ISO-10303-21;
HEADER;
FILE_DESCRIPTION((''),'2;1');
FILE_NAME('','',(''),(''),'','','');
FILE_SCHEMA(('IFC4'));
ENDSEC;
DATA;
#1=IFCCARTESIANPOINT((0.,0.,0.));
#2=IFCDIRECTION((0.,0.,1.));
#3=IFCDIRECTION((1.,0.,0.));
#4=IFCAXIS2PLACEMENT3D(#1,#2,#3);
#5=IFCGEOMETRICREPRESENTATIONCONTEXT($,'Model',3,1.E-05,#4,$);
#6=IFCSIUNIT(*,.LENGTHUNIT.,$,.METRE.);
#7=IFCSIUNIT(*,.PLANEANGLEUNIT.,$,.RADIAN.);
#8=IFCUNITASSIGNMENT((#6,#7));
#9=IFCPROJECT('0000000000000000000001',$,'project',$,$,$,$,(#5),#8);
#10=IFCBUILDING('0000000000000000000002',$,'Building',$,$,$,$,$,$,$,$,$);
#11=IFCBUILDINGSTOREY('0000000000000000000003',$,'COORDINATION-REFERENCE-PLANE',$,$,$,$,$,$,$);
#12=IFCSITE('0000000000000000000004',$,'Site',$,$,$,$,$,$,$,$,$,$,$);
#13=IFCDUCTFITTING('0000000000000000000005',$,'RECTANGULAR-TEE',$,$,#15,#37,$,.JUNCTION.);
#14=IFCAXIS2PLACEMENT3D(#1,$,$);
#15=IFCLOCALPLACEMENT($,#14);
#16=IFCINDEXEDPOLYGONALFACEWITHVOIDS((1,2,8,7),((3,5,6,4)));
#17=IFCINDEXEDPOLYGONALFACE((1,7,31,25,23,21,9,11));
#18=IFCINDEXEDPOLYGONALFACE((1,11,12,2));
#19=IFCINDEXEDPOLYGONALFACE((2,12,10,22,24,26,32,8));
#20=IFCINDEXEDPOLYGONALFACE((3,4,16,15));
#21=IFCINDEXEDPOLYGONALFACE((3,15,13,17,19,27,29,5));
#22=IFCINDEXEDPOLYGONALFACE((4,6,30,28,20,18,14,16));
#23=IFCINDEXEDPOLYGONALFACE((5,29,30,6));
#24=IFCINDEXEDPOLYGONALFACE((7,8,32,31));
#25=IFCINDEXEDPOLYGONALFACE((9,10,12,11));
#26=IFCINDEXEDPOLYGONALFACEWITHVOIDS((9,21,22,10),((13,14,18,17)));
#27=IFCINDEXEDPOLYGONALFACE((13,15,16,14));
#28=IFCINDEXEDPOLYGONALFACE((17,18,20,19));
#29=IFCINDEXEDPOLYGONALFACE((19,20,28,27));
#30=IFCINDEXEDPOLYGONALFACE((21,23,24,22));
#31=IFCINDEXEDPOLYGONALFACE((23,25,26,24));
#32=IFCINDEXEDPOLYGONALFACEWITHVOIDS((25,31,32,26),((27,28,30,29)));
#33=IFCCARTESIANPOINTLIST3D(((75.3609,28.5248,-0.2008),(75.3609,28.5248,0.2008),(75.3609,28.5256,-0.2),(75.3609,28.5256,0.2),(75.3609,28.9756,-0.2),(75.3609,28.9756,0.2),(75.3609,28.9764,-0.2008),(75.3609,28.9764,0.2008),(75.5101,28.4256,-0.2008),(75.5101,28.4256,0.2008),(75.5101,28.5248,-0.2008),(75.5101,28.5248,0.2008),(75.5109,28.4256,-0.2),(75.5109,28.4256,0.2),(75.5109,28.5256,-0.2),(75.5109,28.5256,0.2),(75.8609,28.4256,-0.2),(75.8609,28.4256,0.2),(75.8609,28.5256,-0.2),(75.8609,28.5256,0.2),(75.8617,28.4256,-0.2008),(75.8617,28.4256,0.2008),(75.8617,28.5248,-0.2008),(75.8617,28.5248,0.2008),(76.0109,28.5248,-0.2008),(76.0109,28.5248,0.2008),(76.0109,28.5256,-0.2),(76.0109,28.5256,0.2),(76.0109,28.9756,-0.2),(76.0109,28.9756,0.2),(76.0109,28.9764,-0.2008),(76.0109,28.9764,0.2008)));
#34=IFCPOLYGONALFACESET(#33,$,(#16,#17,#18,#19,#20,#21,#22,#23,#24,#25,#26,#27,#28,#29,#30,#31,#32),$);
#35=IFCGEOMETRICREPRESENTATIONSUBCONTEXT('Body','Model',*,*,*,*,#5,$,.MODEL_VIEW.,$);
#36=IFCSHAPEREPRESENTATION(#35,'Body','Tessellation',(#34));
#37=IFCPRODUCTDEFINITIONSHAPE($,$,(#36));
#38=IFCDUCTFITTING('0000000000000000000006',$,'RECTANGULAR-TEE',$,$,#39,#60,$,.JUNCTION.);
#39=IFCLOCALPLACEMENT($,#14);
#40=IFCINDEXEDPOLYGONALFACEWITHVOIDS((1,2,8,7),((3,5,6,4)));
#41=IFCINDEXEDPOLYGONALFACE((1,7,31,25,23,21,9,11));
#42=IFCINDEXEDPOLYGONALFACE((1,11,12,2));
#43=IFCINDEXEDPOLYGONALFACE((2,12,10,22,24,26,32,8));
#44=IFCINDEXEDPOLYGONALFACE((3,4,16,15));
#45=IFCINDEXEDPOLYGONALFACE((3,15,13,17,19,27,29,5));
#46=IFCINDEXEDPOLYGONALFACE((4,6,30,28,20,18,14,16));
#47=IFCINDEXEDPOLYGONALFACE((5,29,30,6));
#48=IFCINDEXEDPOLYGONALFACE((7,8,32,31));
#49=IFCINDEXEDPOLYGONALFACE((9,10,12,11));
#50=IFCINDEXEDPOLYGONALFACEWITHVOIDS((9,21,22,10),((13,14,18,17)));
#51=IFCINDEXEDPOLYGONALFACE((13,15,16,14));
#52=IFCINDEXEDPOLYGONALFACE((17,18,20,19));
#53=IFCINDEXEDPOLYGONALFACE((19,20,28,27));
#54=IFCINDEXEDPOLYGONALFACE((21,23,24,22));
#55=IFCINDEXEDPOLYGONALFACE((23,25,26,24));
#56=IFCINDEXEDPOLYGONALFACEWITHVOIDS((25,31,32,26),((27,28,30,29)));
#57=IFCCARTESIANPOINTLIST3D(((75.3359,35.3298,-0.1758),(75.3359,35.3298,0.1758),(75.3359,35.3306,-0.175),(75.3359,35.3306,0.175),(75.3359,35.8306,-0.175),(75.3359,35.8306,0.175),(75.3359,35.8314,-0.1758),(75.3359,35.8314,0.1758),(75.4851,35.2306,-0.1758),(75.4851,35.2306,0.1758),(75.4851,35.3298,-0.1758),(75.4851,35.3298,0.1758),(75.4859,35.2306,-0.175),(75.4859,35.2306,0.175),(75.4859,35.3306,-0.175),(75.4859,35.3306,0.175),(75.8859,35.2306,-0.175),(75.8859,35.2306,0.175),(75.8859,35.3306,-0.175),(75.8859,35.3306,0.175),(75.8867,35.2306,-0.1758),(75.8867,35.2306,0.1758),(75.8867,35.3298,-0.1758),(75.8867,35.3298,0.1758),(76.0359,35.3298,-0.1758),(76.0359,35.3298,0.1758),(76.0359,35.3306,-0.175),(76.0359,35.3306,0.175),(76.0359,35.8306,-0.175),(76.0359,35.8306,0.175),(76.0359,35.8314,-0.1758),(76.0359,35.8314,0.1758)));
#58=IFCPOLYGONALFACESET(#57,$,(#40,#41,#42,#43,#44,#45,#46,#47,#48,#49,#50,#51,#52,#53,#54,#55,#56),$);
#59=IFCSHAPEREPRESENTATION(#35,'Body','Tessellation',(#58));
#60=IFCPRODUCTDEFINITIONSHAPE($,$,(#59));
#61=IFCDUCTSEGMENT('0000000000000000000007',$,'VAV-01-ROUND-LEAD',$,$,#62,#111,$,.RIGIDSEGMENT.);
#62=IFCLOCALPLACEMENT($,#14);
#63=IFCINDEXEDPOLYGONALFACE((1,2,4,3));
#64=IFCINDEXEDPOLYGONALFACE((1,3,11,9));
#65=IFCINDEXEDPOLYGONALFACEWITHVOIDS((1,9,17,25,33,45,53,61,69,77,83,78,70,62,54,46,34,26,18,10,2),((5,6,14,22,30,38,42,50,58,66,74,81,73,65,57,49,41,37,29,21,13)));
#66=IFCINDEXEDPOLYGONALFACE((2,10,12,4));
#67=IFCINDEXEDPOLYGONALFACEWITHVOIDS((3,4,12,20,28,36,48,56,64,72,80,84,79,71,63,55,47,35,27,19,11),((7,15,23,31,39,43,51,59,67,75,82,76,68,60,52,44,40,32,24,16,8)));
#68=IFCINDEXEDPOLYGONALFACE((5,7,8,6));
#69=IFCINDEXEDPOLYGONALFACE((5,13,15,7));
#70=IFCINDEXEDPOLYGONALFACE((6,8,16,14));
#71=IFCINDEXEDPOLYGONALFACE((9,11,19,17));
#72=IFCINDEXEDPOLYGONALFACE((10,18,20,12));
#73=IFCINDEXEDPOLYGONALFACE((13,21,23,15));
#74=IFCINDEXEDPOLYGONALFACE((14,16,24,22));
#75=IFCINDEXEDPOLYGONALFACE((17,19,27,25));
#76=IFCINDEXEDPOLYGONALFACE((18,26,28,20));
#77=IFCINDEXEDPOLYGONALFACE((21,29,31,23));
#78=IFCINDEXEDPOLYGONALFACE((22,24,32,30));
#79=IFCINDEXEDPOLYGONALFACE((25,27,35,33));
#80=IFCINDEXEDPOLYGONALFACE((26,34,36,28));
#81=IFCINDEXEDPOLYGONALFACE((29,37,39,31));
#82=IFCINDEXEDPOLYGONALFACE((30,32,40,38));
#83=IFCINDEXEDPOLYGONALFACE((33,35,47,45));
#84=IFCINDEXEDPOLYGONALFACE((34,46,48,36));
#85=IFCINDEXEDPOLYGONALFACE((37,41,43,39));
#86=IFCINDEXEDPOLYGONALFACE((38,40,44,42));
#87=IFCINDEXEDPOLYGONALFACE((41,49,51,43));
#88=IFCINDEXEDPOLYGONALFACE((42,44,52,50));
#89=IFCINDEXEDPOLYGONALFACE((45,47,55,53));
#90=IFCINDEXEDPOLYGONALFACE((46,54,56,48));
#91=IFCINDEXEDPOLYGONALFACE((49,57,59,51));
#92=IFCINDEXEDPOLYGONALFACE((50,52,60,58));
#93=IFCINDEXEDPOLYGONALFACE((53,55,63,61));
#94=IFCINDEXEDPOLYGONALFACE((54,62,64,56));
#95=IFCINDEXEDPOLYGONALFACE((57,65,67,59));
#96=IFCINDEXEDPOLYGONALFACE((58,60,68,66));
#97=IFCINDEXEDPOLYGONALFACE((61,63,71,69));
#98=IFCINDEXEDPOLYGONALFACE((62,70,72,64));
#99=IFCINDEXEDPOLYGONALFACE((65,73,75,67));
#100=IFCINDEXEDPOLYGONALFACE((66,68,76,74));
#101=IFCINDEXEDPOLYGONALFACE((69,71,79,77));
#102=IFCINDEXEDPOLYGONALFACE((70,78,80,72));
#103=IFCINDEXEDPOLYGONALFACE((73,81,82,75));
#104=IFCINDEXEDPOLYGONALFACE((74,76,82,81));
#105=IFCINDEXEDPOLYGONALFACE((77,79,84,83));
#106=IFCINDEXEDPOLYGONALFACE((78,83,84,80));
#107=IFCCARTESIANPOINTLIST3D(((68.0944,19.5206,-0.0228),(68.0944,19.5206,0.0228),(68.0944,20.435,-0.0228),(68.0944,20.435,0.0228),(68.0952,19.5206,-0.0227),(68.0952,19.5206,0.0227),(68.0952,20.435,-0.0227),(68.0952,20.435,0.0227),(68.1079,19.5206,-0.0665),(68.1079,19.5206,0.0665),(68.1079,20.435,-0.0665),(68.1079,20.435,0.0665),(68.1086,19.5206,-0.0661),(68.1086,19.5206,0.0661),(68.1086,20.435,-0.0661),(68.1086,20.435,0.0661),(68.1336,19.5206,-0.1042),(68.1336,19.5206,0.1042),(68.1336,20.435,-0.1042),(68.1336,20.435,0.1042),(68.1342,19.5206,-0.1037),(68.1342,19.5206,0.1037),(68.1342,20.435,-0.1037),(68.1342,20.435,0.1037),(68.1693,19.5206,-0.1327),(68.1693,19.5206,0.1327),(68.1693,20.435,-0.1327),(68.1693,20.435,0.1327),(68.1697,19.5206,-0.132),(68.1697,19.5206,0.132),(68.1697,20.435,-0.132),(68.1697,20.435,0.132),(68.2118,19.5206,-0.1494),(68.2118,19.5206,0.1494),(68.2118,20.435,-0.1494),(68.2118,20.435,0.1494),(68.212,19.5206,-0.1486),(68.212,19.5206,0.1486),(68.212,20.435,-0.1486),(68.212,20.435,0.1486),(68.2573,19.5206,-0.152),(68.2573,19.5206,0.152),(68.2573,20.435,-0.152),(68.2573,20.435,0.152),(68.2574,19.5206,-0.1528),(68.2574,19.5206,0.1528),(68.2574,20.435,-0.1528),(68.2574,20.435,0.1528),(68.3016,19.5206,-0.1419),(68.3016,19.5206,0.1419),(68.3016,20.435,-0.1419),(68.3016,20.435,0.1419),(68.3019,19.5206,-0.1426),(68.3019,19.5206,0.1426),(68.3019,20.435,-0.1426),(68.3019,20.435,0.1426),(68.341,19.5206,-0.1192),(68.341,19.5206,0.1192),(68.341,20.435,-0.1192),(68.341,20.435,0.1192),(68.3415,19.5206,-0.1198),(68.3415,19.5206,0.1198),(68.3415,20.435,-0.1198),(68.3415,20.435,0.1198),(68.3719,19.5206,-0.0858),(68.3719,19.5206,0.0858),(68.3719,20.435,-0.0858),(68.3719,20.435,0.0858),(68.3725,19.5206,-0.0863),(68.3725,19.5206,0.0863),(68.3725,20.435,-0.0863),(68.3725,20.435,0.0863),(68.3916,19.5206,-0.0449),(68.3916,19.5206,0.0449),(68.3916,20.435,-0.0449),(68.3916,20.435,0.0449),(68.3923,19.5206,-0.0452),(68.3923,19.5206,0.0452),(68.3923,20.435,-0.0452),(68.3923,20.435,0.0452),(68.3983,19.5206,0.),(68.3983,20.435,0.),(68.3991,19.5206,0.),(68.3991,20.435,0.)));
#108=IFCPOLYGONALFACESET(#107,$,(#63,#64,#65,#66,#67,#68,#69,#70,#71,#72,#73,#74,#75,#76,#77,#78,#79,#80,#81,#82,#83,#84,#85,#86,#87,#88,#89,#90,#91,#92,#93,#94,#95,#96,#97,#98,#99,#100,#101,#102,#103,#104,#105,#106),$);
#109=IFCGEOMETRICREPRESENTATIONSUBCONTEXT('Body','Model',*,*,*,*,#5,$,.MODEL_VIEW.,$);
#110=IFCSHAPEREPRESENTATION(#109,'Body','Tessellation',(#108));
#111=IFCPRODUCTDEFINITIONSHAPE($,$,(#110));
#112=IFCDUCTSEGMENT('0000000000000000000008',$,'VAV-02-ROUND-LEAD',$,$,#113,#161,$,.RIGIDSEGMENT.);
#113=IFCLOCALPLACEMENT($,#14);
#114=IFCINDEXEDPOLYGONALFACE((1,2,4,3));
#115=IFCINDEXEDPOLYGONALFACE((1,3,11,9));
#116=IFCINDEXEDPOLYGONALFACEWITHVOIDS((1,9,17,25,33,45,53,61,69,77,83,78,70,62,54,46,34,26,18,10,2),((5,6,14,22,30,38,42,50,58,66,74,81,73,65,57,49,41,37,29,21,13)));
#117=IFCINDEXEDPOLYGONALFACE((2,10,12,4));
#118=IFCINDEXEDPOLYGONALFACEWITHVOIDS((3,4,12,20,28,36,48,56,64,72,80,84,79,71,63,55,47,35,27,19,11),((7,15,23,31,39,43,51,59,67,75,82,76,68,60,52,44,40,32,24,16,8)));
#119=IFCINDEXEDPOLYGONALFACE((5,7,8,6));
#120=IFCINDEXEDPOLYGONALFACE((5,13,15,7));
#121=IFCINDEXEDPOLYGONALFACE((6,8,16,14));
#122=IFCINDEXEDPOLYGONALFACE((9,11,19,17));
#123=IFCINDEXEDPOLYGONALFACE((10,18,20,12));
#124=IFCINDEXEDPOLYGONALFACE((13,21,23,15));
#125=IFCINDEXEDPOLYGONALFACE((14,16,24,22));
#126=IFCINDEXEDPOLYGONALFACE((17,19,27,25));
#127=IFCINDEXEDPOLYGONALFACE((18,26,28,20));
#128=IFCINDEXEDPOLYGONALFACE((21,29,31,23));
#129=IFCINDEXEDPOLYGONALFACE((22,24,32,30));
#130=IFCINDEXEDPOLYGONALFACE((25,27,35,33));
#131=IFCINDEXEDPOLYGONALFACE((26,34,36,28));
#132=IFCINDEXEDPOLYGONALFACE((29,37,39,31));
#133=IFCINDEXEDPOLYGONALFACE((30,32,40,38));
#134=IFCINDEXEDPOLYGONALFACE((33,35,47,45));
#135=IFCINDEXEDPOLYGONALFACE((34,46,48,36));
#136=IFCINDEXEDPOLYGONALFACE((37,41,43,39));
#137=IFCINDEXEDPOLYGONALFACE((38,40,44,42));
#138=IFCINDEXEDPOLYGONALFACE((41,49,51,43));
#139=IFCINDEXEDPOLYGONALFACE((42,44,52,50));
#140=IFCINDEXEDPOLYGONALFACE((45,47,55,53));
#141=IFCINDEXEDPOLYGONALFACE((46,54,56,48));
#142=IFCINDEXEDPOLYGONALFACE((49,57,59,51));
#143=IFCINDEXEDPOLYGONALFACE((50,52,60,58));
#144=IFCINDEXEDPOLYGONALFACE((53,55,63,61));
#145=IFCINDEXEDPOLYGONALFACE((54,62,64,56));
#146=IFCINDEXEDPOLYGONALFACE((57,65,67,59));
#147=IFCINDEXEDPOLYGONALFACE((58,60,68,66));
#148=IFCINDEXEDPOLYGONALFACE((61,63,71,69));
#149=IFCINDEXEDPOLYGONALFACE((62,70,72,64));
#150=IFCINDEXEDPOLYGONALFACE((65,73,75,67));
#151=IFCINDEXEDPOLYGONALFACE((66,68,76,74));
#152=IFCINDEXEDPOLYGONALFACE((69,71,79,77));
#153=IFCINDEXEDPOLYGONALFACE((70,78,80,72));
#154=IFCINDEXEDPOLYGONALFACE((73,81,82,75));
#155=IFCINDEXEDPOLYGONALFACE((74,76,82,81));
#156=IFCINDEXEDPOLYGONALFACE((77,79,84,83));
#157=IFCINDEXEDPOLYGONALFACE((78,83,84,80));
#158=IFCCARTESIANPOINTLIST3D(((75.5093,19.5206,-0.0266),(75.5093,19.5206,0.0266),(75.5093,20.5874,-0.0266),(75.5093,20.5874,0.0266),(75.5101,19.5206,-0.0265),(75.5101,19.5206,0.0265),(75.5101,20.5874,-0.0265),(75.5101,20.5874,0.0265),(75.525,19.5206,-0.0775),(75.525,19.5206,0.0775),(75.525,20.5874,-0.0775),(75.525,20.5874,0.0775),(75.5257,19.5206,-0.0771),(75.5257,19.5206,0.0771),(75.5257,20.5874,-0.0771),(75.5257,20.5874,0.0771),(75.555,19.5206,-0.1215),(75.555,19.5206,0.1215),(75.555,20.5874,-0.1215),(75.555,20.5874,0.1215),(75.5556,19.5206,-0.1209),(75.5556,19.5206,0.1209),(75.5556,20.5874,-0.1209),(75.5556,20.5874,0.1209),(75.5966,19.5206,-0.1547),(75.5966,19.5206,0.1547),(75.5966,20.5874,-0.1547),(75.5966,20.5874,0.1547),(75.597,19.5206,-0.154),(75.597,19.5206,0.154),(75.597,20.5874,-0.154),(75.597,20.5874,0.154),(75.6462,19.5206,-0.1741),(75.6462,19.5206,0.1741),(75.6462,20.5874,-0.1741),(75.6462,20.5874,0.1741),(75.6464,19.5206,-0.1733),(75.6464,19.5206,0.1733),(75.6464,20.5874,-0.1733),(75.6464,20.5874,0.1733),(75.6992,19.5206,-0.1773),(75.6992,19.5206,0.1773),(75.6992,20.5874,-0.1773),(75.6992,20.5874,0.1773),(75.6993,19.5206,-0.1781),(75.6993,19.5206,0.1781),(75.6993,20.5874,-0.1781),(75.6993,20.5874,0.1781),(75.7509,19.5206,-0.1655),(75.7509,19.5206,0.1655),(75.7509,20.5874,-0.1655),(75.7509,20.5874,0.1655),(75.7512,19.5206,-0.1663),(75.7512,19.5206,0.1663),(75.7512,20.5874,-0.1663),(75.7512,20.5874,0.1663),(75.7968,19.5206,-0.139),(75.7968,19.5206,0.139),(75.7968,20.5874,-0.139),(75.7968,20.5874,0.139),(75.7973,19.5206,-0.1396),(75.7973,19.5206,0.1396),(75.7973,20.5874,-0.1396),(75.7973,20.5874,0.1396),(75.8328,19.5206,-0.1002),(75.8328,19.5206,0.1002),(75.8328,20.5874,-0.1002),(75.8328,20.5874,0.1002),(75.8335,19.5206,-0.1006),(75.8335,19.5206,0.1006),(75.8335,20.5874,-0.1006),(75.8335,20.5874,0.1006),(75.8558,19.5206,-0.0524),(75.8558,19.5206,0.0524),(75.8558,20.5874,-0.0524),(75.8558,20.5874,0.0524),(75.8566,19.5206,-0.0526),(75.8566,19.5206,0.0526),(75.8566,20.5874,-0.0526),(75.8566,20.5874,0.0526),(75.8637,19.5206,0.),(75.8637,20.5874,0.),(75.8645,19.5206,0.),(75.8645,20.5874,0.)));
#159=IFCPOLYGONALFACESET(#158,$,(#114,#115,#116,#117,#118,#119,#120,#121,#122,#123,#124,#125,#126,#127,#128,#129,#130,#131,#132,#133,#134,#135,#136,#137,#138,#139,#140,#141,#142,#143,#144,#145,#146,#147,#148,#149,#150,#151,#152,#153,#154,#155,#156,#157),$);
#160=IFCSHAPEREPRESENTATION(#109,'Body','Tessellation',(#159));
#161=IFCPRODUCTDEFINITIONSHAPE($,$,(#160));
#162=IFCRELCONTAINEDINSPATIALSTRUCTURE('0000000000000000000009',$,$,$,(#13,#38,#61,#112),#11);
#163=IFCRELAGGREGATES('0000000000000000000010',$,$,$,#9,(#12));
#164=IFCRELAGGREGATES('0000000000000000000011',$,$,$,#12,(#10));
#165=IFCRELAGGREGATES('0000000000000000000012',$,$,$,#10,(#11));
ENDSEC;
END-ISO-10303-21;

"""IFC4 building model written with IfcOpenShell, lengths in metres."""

from ifc_helpers import new_model, si_unit, frame, origin, origin_with_axes, place, context, subcontext, project, spatial, rectangle, hollow_circle, extrude, boolean, element, save


model = new_model("IFC4")

# Units and contexts
model_context = context("Model", 3, precision=1e-05, world=origin_with_axes())
body_context_1 = subcontext(model_context, "Body", "Model", "MODEL_VIEW")
body_context_2 = subcontext(model_context, "Body", "Model", "MODEL_VIEW")
ifc_project = project(units=[si_unit("LENGTHUNIT", "METRE"), si_unit("PLANEANGLEUNIT", "RADIAN")], contexts=[model_context])

# Site, building, storey
site = spatial("IfcSite", under=ifc_project, Name="Site")
building = spatial("IfcBuilding", under=site, Name="Building")
storey = spatial("IfcBuildingStorey", under=building, Name="COORDINATION-REFERENCE-PLANE")

# Duct fittings
duct_fitting_1_placement = place(None, frame((75.6859, 28.7506, 0.0), z_axis=(-1.0, 0.0, 0.0), x_axis=(0.0, -1.0, 0.0)))
solid_1 = boolean("UNION", extrude(rectangle(XDim=0.45, YDim=0.4), frame((0.0, 0.0, -0.325), z_axis=(0.0, 0.0, 1.0), x_axis=(1.0, 0.0, 0.0)), (0.0, 0.0, 1.0), 0.65), extrude(rectangle(XDim=0.35, YDim=0.4), frame((0.0, 0.0, 0.0), z_axis=(1.0, 0.0, 0.0), x_axis=(0.0, 0.0, -1.0)), (0.0, 0.0, 1.0), 0.325))
element("IfcDuctFitting", 1, at=duct_fitting_1_placement, inside=storey, Name="RECTANGULAR-TEE", PredefinedType="JUNCTION", context=body_context_1, shape_type="CSG", body=[
    boolean("DIFFERENCE", boolean("UNION", extrude(rectangle(XDim=0.4516, YDim=0.4016), frame((0.0, 0.0, -0.325), z_axis=(0.0, 0.0, 1.0), x_axis=(1.0, 0.0, 0.0)), (0.0, 0.0, 1.0), 0.65), extrude(rectangle(XDim=0.3516, YDim=0.4016), frame((0.0, 0.0, 0.0), z_axis=(1.0, 0.0, 0.0), x_axis=(0.0, 0.0, -1.0)), (0.0, 0.0, 1.0), 0.325)), solid_1),
])
duct_fitting_2_placement = place(None, frame((75.6859, 35.5806, 0.0), z_axis=(-1.0, 0.0, 0.0), x_axis=(0.0, -1.0, 0.0)))
solid_2 = boolean("UNION", extrude(rectangle(XDim=0.5, YDim=0.35), frame((0.0, 0.0, -0.35), z_axis=(0.0, 0.0, 1.0), x_axis=(1.0, 0.0, 0.0)), (0.0, 0.0, 1.0), 0.7), extrude(rectangle(XDim=0.4, YDim=0.35), frame((0.0, 0.0, 0.0), z_axis=(1.0, 0.0, 0.0), x_axis=(0.0, 0.0, -1.0)), (0.0, 0.0, 1.0), 0.35))
element("IfcDuctFitting", 2, at=duct_fitting_2_placement, inside=storey, Name="RECTANGULAR-TEE", PredefinedType="JUNCTION", context=body_context_1, shape_type="CSG", body=[
    boolean("DIFFERENCE", boolean("UNION", extrude(rectangle(XDim=0.5016, YDim=0.3516), frame((0.0, 0.0, -0.35), z_axis=(0.0, 0.0, 1.0), x_axis=(1.0, 0.0, 0.0)), (0.0, 0.0, 1.0), 0.7), extrude(rectangle(XDim=0.4016, YDim=0.3516), frame((0.0, 0.0, 0.0), z_axis=(1.0, 0.0, 0.0), x_axis=(0.0, 0.0, -1.0)), (0.0, 0.0, 1.0), 0.35)), solid_2),
])

# Duct segments
duct_segment_1_placement = place(None, frame((68.2459, 20.435, 0.0), z_axis=(0.0, -1.0, 0.0), x_axis=(1.0, 0.0, 0.0)))
element("IfcDuctSegment", 3, at=duct_segment_1_placement, inside=storey, Name="VAV-01-ROUND-LEAD", PredefinedType="RIGIDSEGMENT", context=body_context_2, shape_type="SweptSolid", body=[
    extrude(hollow_circle(Radius=0.1532, WallThickness=0.0008), origin(), (0.0, 0.0, 1.0), 0.9144),
])
for number, where, z_axis, x_axis, name in (
    (4, (75.6859, 20.5874, 0.0), (0.0, -1.0, 0.0), (1.0, 0.0, 0.0), "VAV-02-ROUND-LEAD"),
):
    element("IfcDuctSegment", number, at=place(None, frame(where, z_axis=z_axis, x_axis=x_axis)), inside=storey, Name=name, PredefinedType="RIGIDSEGMENT", context=body_context_2, shape_type="SweptSolid", body=[
        extrude(hollow_circle(Radius=0.1786, WallThickness=0.0008), origin(), (0.0, 0.0, 1.0), 1.0668),
    ])

save(model, "model.ifc")
